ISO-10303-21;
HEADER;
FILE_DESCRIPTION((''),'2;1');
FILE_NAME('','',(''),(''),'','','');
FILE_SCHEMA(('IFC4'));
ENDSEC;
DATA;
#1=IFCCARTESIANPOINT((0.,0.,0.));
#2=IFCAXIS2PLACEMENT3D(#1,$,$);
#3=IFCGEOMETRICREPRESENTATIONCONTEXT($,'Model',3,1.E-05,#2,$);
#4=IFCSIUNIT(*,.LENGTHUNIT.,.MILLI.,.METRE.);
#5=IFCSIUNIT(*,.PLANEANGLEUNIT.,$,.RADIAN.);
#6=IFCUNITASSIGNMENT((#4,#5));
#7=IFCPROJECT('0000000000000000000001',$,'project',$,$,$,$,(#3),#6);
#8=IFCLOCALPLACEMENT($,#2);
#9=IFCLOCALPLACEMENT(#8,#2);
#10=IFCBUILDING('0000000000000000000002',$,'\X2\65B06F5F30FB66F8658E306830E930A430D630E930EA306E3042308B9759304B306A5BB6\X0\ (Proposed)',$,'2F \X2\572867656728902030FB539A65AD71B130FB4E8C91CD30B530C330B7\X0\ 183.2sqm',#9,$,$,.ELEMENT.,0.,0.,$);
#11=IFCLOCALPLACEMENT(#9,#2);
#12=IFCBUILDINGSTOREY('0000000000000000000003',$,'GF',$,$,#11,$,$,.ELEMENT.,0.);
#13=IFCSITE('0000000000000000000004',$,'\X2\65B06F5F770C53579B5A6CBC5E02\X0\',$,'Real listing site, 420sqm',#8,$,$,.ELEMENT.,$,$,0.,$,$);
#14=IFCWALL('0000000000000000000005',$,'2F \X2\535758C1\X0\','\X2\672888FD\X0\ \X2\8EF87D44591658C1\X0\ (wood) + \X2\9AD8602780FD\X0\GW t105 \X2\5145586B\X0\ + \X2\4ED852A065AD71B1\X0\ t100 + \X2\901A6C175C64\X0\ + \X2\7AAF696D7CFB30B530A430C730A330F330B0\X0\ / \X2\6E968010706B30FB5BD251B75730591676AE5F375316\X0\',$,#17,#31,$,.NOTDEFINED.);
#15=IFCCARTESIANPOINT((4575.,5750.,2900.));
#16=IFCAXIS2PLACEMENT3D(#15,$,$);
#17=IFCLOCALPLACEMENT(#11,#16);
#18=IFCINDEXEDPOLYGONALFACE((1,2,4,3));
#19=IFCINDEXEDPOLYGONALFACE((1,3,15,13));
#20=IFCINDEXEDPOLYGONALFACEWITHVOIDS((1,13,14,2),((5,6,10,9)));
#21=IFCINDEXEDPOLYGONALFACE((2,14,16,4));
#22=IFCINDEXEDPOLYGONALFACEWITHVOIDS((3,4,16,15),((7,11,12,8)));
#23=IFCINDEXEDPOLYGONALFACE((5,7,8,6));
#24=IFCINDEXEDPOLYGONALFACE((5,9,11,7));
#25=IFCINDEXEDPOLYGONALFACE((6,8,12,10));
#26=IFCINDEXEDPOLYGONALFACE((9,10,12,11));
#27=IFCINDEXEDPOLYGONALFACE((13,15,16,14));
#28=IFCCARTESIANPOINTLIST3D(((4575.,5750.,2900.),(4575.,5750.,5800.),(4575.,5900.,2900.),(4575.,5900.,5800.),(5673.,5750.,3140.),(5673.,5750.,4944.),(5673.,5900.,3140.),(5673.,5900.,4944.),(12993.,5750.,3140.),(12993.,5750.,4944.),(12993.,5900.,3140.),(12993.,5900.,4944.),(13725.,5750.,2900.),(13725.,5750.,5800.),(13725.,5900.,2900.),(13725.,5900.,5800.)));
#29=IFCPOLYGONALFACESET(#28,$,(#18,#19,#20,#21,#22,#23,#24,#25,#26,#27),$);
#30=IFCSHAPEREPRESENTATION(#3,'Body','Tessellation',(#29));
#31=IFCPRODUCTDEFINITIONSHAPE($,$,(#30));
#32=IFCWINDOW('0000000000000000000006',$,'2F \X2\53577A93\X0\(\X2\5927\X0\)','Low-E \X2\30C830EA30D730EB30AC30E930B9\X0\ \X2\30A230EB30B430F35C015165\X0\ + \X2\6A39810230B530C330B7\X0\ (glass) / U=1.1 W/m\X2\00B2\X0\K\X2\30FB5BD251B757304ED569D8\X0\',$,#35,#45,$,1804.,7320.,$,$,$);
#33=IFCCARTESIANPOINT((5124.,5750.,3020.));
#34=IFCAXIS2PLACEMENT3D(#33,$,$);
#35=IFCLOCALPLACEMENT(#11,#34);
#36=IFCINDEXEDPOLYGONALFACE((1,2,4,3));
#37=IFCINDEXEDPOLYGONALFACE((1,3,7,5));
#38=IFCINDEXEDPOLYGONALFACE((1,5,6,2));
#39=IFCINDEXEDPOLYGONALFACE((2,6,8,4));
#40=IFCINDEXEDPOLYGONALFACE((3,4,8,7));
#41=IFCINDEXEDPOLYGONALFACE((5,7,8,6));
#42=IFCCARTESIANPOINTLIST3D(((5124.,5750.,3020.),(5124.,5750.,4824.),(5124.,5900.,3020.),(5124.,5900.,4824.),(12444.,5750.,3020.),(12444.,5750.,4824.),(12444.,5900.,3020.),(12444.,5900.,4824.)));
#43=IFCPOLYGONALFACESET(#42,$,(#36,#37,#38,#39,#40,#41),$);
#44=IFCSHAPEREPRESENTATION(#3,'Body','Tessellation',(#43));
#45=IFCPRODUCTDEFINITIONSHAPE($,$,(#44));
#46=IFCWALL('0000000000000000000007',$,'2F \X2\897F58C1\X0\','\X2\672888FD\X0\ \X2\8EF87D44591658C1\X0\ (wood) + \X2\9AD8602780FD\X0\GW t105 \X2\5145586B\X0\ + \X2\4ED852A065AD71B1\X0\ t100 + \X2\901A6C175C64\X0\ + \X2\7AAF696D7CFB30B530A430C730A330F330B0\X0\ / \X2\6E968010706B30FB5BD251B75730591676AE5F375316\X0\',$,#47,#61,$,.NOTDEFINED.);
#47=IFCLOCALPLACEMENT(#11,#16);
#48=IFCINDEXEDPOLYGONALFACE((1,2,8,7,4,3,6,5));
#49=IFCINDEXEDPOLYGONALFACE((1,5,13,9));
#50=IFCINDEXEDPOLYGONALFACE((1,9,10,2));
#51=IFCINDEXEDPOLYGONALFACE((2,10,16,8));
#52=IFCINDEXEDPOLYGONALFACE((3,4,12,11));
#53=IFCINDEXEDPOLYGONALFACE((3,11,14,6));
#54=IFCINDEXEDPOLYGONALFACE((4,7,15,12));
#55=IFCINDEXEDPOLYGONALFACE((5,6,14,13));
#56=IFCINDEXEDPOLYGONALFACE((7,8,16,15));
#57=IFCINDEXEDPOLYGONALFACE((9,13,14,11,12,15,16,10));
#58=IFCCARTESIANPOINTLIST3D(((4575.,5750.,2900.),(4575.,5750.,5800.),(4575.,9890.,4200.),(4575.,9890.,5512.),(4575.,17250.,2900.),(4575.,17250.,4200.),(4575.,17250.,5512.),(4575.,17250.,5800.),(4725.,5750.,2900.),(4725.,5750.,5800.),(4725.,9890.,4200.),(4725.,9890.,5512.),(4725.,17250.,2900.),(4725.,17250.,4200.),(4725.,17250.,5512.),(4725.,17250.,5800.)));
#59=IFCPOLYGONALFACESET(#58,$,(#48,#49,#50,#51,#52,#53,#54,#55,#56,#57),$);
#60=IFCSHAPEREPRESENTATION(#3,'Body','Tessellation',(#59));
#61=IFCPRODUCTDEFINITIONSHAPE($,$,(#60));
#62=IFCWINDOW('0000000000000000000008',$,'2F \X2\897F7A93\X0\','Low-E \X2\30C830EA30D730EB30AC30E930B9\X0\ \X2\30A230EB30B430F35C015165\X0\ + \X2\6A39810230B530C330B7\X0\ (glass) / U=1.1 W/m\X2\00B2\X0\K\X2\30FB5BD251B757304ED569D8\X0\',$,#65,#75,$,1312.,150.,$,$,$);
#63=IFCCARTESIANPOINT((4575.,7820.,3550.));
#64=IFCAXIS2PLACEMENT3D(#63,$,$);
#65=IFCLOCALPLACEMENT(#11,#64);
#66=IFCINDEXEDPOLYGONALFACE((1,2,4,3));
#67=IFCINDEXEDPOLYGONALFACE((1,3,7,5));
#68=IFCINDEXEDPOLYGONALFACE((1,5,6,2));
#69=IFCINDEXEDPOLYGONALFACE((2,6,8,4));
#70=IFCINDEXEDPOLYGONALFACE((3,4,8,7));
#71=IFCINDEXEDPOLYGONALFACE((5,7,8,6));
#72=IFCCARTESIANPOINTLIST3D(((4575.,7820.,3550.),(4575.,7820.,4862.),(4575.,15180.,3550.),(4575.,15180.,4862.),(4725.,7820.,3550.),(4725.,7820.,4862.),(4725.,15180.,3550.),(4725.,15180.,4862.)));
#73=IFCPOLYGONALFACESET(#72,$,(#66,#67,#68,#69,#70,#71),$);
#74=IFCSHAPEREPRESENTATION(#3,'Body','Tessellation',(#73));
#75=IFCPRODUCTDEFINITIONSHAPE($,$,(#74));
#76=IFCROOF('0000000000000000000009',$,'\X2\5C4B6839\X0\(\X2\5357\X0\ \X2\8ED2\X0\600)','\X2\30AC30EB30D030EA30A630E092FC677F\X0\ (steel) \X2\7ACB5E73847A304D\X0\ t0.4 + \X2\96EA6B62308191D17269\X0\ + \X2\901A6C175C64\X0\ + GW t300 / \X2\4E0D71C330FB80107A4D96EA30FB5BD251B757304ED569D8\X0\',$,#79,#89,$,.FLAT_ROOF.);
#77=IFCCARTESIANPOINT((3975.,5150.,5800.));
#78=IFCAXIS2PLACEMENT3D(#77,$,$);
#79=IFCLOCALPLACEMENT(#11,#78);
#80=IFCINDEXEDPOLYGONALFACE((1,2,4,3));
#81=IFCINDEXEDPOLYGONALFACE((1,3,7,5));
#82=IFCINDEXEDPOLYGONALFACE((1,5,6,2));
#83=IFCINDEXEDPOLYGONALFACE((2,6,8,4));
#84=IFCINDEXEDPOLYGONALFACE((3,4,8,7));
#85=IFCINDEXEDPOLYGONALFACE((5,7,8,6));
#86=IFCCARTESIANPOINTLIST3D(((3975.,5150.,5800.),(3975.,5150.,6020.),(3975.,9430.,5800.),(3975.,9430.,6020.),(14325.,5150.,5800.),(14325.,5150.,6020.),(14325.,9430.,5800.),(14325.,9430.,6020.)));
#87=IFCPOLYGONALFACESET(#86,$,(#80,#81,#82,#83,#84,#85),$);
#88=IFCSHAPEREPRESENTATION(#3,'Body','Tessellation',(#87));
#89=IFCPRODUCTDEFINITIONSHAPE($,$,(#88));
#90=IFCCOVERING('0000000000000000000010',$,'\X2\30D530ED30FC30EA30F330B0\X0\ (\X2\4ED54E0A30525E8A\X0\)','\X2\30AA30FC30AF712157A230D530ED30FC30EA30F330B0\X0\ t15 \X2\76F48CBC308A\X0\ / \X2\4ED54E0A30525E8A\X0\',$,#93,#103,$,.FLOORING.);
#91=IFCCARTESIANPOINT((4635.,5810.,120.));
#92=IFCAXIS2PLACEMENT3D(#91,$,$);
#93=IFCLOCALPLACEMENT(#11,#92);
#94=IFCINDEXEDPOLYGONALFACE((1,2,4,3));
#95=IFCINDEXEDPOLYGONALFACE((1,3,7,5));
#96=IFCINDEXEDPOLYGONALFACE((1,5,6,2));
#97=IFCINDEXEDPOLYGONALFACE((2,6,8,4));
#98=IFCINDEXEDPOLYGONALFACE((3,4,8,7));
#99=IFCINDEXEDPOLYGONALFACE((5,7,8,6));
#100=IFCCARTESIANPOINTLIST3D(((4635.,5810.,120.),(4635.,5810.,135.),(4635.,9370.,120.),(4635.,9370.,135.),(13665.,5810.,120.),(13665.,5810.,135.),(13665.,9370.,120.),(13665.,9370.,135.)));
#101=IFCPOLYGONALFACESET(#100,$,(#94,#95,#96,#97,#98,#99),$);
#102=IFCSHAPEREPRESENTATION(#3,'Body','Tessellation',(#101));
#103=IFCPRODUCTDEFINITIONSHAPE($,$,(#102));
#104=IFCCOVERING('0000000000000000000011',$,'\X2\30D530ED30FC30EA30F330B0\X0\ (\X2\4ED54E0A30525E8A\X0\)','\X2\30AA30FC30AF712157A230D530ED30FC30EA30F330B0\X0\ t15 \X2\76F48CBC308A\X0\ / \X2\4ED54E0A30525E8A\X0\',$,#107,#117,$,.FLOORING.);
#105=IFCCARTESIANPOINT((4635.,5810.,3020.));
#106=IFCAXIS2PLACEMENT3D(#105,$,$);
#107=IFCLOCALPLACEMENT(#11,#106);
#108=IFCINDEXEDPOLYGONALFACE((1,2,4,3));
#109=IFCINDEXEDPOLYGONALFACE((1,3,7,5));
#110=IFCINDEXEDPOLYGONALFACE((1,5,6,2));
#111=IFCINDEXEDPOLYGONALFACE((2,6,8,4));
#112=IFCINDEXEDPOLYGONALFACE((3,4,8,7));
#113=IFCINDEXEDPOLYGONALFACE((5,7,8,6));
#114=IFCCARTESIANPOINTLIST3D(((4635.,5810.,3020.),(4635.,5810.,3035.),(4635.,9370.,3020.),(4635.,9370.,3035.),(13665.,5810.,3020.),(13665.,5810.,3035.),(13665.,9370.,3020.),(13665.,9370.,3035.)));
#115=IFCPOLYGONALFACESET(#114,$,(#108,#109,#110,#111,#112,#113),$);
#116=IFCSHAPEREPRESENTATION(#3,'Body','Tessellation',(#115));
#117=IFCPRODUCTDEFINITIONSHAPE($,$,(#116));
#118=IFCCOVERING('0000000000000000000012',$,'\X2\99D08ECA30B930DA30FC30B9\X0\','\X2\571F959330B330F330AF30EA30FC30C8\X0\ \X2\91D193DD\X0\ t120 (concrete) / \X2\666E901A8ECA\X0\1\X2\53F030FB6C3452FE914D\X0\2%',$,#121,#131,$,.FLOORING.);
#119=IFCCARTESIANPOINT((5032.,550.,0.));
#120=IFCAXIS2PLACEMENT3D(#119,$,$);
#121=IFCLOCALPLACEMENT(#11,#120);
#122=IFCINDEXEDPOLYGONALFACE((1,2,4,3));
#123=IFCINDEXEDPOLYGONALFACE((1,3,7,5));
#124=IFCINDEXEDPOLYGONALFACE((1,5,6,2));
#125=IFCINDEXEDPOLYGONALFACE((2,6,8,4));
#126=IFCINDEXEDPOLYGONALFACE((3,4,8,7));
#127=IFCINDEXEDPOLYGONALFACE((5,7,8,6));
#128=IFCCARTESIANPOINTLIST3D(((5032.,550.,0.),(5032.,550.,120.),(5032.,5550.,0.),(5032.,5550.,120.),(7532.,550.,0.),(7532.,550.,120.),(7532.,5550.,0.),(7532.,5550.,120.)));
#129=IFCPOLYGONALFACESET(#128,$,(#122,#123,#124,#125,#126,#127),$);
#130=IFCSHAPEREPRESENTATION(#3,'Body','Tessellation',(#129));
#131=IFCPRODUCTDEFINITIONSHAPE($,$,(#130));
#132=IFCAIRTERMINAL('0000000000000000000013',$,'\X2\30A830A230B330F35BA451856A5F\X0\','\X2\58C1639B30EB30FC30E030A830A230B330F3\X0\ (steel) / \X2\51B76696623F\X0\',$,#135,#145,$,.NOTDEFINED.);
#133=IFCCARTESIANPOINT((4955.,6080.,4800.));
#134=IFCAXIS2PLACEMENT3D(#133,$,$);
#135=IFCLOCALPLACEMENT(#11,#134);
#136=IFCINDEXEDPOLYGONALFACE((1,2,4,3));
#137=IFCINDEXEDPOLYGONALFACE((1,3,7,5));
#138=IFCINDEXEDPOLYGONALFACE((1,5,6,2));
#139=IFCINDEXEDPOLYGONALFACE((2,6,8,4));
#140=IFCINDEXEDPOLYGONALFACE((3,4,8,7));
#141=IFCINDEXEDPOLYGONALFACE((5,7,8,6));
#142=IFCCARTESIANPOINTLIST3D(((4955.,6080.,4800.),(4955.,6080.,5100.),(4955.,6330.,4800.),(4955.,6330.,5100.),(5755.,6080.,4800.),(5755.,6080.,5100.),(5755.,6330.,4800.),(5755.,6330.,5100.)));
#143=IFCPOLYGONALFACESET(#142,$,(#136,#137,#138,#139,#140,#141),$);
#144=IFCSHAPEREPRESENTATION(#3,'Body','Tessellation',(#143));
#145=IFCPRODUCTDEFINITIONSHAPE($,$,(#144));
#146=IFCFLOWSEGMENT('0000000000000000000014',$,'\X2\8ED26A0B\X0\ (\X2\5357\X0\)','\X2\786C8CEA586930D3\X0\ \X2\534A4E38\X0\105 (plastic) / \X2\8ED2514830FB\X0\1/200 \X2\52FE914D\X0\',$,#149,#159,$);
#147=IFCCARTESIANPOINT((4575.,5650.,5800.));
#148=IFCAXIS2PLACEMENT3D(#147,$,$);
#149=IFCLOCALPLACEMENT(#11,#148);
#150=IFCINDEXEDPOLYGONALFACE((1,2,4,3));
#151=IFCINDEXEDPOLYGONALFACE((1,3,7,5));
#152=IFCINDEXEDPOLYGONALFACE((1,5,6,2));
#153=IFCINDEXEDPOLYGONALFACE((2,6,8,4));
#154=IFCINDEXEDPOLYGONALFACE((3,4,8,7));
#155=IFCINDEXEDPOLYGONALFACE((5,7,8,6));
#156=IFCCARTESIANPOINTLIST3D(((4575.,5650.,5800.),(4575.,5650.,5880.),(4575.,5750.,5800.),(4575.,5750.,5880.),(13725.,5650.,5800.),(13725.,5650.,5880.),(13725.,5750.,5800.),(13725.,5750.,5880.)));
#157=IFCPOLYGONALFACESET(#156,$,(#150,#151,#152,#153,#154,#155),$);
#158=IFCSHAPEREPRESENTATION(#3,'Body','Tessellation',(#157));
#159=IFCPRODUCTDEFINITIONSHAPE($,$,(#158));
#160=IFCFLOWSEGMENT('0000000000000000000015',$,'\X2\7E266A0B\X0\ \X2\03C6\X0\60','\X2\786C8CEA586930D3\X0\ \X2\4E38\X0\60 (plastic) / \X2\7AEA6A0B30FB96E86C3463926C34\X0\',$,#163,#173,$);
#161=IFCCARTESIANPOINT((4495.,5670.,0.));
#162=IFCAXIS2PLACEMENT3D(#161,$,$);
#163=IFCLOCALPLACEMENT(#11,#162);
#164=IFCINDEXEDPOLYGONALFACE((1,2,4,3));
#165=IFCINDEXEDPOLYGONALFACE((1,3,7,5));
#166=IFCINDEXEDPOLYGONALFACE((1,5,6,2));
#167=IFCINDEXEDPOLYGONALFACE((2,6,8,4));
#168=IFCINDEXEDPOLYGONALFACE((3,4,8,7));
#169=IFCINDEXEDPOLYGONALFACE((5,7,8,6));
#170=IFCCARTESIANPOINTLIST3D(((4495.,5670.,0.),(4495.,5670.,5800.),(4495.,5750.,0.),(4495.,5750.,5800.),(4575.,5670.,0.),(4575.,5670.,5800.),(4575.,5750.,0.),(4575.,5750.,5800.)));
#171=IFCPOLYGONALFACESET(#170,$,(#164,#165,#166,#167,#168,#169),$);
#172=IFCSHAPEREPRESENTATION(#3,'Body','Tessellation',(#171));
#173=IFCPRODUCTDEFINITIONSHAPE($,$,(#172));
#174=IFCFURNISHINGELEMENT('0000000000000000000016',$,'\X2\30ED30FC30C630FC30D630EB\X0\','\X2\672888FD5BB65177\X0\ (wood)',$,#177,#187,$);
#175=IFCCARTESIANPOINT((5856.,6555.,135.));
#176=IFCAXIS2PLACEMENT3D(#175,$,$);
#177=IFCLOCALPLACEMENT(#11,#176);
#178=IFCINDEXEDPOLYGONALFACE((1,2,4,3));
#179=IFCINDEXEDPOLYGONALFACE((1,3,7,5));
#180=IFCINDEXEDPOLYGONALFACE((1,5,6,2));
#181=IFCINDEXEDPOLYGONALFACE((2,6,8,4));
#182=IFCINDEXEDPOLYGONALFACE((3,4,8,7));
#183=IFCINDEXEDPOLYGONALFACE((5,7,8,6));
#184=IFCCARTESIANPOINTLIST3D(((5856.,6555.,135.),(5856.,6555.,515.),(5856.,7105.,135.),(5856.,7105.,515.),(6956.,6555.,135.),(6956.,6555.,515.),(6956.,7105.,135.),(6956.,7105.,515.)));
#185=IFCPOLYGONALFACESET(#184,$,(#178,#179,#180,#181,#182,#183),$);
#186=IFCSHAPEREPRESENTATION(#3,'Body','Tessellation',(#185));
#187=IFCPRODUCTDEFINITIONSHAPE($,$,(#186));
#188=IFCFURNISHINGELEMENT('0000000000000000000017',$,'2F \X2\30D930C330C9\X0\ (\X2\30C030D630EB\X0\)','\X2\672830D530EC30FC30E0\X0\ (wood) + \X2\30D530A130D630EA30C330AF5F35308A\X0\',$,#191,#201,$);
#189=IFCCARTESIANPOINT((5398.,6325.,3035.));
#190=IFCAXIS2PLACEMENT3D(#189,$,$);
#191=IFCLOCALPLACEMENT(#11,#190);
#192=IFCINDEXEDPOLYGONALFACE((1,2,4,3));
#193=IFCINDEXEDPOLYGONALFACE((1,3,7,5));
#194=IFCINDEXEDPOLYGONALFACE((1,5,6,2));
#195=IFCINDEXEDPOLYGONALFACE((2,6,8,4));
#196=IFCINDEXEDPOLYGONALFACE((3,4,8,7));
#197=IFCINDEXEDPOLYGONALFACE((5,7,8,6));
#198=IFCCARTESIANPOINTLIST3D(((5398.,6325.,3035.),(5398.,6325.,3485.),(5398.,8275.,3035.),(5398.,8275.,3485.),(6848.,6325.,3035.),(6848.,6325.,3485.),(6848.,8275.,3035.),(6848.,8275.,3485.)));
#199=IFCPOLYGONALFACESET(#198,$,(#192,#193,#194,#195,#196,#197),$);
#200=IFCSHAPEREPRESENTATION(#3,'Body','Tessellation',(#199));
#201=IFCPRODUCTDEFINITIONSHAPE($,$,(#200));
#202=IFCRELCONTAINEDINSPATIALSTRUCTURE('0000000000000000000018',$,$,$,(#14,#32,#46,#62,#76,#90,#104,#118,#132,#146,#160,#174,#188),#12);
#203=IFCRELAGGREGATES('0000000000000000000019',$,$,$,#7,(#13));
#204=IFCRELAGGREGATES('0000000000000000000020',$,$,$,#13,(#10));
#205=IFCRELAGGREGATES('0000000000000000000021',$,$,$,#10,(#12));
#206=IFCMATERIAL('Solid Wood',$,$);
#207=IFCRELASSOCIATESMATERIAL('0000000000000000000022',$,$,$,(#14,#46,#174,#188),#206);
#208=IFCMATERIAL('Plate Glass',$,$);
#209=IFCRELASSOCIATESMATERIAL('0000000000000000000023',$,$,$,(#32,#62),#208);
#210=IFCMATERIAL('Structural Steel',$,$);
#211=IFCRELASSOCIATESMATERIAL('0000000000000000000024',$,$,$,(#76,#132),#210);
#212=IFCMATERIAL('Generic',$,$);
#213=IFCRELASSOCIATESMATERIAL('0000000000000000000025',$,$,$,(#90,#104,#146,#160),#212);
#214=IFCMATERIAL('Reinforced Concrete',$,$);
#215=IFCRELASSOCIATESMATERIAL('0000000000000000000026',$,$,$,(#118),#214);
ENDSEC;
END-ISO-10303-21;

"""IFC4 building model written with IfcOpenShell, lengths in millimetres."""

from ifc_helpers import new_model, si_unit, frame, frame_2d, origin, place, context, project, spatial, rectangle, extrude, material, element, fill, save


model = new_model("IFC4")

# Units and contexts
model_context = context("Model", 3, precision=1e-05, world=origin())
ifc_project = project(units=[si_unit("LENGTHUNIT", "METRE", prefix="MILLI"), si_unit("PLANEANGLEUNIT", "RADIAN")], contexts=[model_context])

# Site, building, storey
site_placement = place(None, origin())
site = spatial("IfcSite", under=ifc_project, at=site_placement, Name="新潟県南魚沼市", ObjectType="Real listing site, 420sqm", CompositionType="ELEMENT", RefElevation=0.0)
building_placement = place(site_placement, origin())
building = spatial("IfcBuilding", under=site, at=building_placement, Name="新潟・書斎とライブラリのある静かな家 (Proposed)", ObjectType="2F 在来木造・厚断熱・二重サッシ 183.2sqm", CompositionType="ELEMENT", ElevationOfRefHeight=0.0, ElevationOfTerrain=0.0)
storey_placement = place(building_placement, origin())
storey = spatial("IfcBuildingStorey", under=building, at=storey_placement, Name="GF", CompositionType="ELEMENT", Elevation=0.0)

# Shared definitions
ifc_material_1 = material(Name="Solid Wood")

# Shared definitions
ifc_material_2 = material(Name="Reinforced Concrete")

# Shared definitions
ifc_material_3 = material(Name="Plate Glass")

# Walls, openings, windows
wall_1_placement = place(storey_placement, frame((4575.0, 5750.0, 2900.0)))
wall_1 = element("IfcWall", 1, at=wall_1_placement, inside=storey, material=ifc_material_1, Name="2F 南壁", Description="木製 軸組外壁 (wood) + 高性能GW t105 充填 + 付加断熱 t100 + 通気層 + 窯業系サイディング / 準耐火・寒冷地外皮強化", PredefinedType="NOTDEFINED", context=model_context, shape_type="SweptSolid", body=[
    extrude(rectangle(XDim=9150.0, YDim=150.0, at=frame_2d((4575.0, 75.0))), frame((4575.0, 5750.0, 2900.0)), (0.0, 0.0, 1.0), 2900.0),
])
opening_1_placement = place(storey_placement, frame((5124.0, 5750.0, 3020.0)))
opening_1 = element("IfcOpeningElement", 2, at=opening_1_placement, cuts=wall_1, PredefinedType="NOTDEFINED", context=model_context, shape_type="SweptSolid", body=[
    extrude(rectangle(XDim=7320.0, YDim=150.0, at=frame_2d((3660.0, 75.0))), frame((5124.0, 5750.0, 3020.0)), (0.0, 0.0, 1.0), 1804.0),
])
window_1_placement = place(storey_placement, frame((5124.0, 5750.0, 3020.0)))
window_1 = element("IfcWindow", 3, at=window_1_placement, inside=storey, material=ifc_material_3, Name="2F 南窓(大)", Description="Low-E トリプルガラス アルゴン封入 + 樹脂サッシ (glass) / U=1.1 W/m²K・寒冷地仕様", OverallHeight=1804.0, OverallWidth=7320.0, context=model_context, shape_type="SweptSolid", body=[
    extrude(rectangle(XDim=7320.0, YDim=150.0, at=frame_2d((3660.0, 75.0))), frame((5124.0, 5750.0, 3020.0)), (0.0, 0.0, 1.0), 1804.0),
])
fill(opening_1, window_1)
wall_2_placement = place(storey_placement, frame((4575.0, 5750.0, 2900.0)))
wall_2 = element("IfcWall", 4, at=wall_2_placement, inside=storey, material=ifc_material_1, Name="2F 西壁", Description="木製 軸組外壁 (wood) + 高性能GW t105 充填 + 付加断熱 t100 + 通気層 + 窯業系サイディング / 準耐火・寒冷地外皮強化", PredefinedType="NOTDEFINED", context=model_context, shape_type="SweptSolid", body=[
    extrude(rectangle(XDim=150.0, YDim=11500.0, at=frame_2d((75.0, 5750.0))), frame((4575.0, 5750.0, 2900.0)), (0.0, 0.0, 1.0), 2900.0),
])
opening_2_placement = place(storey_placement, frame((4575.0, 7820.0, 3550.0)))
opening_2 = element("IfcOpeningElement", 5, at=opening_2_placement, cuts=wall_2, PredefinedType="NOTDEFINED", context=model_context, shape_type="SweptSolid", body=[
    extrude(rectangle(XDim=150.0, YDim=7360.0, at=frame_2d((75.0, 3680.0))), frame((4575.0, 7820.0, 3550.0)), (0.0, 0.0, 1.0), 1312.0),
])
window_2_placement = place(storey_placement, frame((4575.0, 7820.0, 3550.0)))
window_2 = element("IfcWindow", 6, at=window_2_placement, inside=storey, material=ifc_material_3, Name="2F 西窓", Description="Low-E トリプルガラス アルゴン封入 + 樹脂サッシ (glass) / U=1.1 W/m²K・寒冷地仕様", OverallHeight=1312.0, OverallWidth=150.0, context=model_context, shape_type="SweptSolid", body=[
    extrude(rectangle(XDim=150.0, YDim=7360.0, at=frame_2d((75.0, 3680.0))), frame((4575.0, 7820.0, 3550.0)), (0.0, 0.0, 1.0), 1312.0),
])
fill(opening_2, window_2)

# Roof
ifc_material_4 = material(Name="Structural Steel")
for number, where, name in (
    (7, (3975.0, 5150.0, 5800.0), "屋根(南 軒600)"),
):
    element("IfcRoof", number, at=place(storey_placement, frame(where)), inside=storey, material=ifc_material_4, Name=name, Description="ガルバリウム鋼板 (steel) 立平葺き t0.4 + 雪止め金物 + 通気層 + GW t300 / 不燃・耐積雪・寒冷地仕様", PredefinedType="FLAT_ROOF", context=model_context, shape_type="SweptSolid", body=[
        extrude(rectangle(XDim=10350.0, YDim=4280.0, at=frame_2d((5175.0, 2140.0))), frame((3975.0, 5150.0, 5800.0)), (0.0, 0.0, 1.0), 220.0),
    ])

# Coverings
ifc_material_5 = material(Name="Generic")
covering_1_placement = place(storey_placement, frame((4635.0, 5810.0, 120.0)))
element("IfcCovering", 8, at=covering_1_placement, inside=storey, material=ifc_material_5, Name="フローリング (仕上げ床)", Description="オーク無垢フローリング t15 直貼り / 仕上げ床", PredefinedType="FLOORING", context=model_context, shape_type="SweptSolid", body=[
    extrude(rectangle(XDim=9030.0, YDim=3560.0, at=frame_2d((4515.0, 1780.0))), frame((4635.0, 5810.0, 120.0)), (0.0, 0.0, 1.0), 15.0),
])
covering_2_placement = place(storey_placement, frame((4635.0, 5810.0, 3020.0)))
element("IfcCovering", 9, at=covering_2_placement, inside=storey, material=ifc_material_5, Name="フローリング (仕上げ床)", Description="オーク無垢フローリング t15 直貼り / 仕上げ床", PredefinedType="FLOORING", context=model_context, shape_type="SweptSolid", body=[
    extrude(rectangle(XDim=9030.0, YDim=3560.0, at=frame_2d((4515.0, 1780.0))), frame((4635.0, 5810.0, 3020.0)), (0.0, 0.0, 1.0), 15.0),
])
covering_3_placement = place(storey_placement, frame((5032.0, 550.0, 0.0)))
element("IfcCovering", 10, at=covering_3_placement, inside=storey, material=ifc_material_2, Name="駐車スペース", Description="土間コンクリート 金鏝 t120 (concrete) / 普通車1台・水勾配2%", PredefinedType="FLOORING", context=model_context, shape_type="SweptSolid", body=[
    extrude(rectangle(XDim=2500.0, YDim=5000.0, at=frame_2d((1250.0, 2500.0))), frame((5032.0, 550.0, 0.0)), (0.0, 0.0, 1.0), 120.0),
])

# Air terminal
air_terminal_placement = place(storey_placement, frame((4955.0, 6080.0, 4800.0)))
element("IfcAirTerminal", 11, at=air_terminal_placement, inside=storey, material=ifc_material_4, Name="エアコン室内機", Description="壁掛ルームエアコン (steel) / 冷暖房", PredefinedType="NOTDEFINED", context=model_context, shape_type="SweptSolid", body=[
    extrude(rectangle(XDim=800.0, YDim=250.0, at=frame_2d((400.0, 125.0))), frame((4955.0, 6080.0, 4800.0)), (0.0, 0.0, 1.0), 300.0),
])

# Flow segments
flow_segment_1_placement = place(storey_placement, frame((4575.0, 5650.0, 5800.0)))
element("IfcFlowSegment", 12, at=flow_segment_1_placement, inside=storey, material=ifc_material_5, Name="軒樋 (南)", Description="硬質塩ビ 半丸105 (plastic) / 軒先・1/200 勾配", context=model_context, shape_type="SweptSolid", body=[
    extrude(rectangle(XDim=9150.0, YDim=100.0, at=frame_2d((4575.0, 50.0))), frame((4575.0, 5650.0, 5800.0)), (0.0, 0.0, 1.0), 80.0),
])
flow_segment_2_placement = place(storey_placement, frame((4495.0, 5670.0, 0.0)))
element("IfcFlowSegment", 13, at=flow_segment_2_placement, inside=storey, material=ifc_material_5, Name="縦樋 φ60", Description="硬質塩ビ 丸60 (plastic) / 竪樋・雨水排水", context=model_context, shape_type="SweptSolid", body=[
    extrude(rectangle(XDim=80.0, YDim=80.0, at=frame_2d((40.0, 40.0))), frame((4495.0, 5670.0, 0.0)), (0.0, 0.0, 1.0), 5800.0),
])

# Furnishing elements
furnishing_1_placement = place(storey_placement, frame((5856.0, 6555.0, 135.0)))
element("IfcFurnishingElement", 14, at=furnishing_1_placement, inside=storey, material=ifc_material_1, Name="ローテーブル", Description="木製家具 (wood)", context=model_context, shape_type="SweptSolid", body=[
    extrude(rectangle(XDim=1100.0, YDim=550.0, at=frame_2d((550.0, 275.0))), frame((5856.0, 6555.0, 135.0)), (0.0, 0.0, 1.0), 380.0),
])
furnishing_2_placement = place(storey_placement, frame((5398.0, 6325.0, 3035.0)))
element("IfcFurnishingElement", 15, at=furnishing_2_placement, inside=storey, material=ifc_material_1, Name="2F ベッド (ダブル)", Description="木フレーム (wood) + ファブリック張り", context=model_context, shape_type="SweptSolid", body=[
    extrude(rectangle(XDim=1450.0, YDim=1950.0, at=frame_2d((725.0, 975.0))), frame((5398.0, 6325.0, 3035.0)), (0.0, 0.0, 1.0), 450.0),
])

save(model, "model.ifc")
